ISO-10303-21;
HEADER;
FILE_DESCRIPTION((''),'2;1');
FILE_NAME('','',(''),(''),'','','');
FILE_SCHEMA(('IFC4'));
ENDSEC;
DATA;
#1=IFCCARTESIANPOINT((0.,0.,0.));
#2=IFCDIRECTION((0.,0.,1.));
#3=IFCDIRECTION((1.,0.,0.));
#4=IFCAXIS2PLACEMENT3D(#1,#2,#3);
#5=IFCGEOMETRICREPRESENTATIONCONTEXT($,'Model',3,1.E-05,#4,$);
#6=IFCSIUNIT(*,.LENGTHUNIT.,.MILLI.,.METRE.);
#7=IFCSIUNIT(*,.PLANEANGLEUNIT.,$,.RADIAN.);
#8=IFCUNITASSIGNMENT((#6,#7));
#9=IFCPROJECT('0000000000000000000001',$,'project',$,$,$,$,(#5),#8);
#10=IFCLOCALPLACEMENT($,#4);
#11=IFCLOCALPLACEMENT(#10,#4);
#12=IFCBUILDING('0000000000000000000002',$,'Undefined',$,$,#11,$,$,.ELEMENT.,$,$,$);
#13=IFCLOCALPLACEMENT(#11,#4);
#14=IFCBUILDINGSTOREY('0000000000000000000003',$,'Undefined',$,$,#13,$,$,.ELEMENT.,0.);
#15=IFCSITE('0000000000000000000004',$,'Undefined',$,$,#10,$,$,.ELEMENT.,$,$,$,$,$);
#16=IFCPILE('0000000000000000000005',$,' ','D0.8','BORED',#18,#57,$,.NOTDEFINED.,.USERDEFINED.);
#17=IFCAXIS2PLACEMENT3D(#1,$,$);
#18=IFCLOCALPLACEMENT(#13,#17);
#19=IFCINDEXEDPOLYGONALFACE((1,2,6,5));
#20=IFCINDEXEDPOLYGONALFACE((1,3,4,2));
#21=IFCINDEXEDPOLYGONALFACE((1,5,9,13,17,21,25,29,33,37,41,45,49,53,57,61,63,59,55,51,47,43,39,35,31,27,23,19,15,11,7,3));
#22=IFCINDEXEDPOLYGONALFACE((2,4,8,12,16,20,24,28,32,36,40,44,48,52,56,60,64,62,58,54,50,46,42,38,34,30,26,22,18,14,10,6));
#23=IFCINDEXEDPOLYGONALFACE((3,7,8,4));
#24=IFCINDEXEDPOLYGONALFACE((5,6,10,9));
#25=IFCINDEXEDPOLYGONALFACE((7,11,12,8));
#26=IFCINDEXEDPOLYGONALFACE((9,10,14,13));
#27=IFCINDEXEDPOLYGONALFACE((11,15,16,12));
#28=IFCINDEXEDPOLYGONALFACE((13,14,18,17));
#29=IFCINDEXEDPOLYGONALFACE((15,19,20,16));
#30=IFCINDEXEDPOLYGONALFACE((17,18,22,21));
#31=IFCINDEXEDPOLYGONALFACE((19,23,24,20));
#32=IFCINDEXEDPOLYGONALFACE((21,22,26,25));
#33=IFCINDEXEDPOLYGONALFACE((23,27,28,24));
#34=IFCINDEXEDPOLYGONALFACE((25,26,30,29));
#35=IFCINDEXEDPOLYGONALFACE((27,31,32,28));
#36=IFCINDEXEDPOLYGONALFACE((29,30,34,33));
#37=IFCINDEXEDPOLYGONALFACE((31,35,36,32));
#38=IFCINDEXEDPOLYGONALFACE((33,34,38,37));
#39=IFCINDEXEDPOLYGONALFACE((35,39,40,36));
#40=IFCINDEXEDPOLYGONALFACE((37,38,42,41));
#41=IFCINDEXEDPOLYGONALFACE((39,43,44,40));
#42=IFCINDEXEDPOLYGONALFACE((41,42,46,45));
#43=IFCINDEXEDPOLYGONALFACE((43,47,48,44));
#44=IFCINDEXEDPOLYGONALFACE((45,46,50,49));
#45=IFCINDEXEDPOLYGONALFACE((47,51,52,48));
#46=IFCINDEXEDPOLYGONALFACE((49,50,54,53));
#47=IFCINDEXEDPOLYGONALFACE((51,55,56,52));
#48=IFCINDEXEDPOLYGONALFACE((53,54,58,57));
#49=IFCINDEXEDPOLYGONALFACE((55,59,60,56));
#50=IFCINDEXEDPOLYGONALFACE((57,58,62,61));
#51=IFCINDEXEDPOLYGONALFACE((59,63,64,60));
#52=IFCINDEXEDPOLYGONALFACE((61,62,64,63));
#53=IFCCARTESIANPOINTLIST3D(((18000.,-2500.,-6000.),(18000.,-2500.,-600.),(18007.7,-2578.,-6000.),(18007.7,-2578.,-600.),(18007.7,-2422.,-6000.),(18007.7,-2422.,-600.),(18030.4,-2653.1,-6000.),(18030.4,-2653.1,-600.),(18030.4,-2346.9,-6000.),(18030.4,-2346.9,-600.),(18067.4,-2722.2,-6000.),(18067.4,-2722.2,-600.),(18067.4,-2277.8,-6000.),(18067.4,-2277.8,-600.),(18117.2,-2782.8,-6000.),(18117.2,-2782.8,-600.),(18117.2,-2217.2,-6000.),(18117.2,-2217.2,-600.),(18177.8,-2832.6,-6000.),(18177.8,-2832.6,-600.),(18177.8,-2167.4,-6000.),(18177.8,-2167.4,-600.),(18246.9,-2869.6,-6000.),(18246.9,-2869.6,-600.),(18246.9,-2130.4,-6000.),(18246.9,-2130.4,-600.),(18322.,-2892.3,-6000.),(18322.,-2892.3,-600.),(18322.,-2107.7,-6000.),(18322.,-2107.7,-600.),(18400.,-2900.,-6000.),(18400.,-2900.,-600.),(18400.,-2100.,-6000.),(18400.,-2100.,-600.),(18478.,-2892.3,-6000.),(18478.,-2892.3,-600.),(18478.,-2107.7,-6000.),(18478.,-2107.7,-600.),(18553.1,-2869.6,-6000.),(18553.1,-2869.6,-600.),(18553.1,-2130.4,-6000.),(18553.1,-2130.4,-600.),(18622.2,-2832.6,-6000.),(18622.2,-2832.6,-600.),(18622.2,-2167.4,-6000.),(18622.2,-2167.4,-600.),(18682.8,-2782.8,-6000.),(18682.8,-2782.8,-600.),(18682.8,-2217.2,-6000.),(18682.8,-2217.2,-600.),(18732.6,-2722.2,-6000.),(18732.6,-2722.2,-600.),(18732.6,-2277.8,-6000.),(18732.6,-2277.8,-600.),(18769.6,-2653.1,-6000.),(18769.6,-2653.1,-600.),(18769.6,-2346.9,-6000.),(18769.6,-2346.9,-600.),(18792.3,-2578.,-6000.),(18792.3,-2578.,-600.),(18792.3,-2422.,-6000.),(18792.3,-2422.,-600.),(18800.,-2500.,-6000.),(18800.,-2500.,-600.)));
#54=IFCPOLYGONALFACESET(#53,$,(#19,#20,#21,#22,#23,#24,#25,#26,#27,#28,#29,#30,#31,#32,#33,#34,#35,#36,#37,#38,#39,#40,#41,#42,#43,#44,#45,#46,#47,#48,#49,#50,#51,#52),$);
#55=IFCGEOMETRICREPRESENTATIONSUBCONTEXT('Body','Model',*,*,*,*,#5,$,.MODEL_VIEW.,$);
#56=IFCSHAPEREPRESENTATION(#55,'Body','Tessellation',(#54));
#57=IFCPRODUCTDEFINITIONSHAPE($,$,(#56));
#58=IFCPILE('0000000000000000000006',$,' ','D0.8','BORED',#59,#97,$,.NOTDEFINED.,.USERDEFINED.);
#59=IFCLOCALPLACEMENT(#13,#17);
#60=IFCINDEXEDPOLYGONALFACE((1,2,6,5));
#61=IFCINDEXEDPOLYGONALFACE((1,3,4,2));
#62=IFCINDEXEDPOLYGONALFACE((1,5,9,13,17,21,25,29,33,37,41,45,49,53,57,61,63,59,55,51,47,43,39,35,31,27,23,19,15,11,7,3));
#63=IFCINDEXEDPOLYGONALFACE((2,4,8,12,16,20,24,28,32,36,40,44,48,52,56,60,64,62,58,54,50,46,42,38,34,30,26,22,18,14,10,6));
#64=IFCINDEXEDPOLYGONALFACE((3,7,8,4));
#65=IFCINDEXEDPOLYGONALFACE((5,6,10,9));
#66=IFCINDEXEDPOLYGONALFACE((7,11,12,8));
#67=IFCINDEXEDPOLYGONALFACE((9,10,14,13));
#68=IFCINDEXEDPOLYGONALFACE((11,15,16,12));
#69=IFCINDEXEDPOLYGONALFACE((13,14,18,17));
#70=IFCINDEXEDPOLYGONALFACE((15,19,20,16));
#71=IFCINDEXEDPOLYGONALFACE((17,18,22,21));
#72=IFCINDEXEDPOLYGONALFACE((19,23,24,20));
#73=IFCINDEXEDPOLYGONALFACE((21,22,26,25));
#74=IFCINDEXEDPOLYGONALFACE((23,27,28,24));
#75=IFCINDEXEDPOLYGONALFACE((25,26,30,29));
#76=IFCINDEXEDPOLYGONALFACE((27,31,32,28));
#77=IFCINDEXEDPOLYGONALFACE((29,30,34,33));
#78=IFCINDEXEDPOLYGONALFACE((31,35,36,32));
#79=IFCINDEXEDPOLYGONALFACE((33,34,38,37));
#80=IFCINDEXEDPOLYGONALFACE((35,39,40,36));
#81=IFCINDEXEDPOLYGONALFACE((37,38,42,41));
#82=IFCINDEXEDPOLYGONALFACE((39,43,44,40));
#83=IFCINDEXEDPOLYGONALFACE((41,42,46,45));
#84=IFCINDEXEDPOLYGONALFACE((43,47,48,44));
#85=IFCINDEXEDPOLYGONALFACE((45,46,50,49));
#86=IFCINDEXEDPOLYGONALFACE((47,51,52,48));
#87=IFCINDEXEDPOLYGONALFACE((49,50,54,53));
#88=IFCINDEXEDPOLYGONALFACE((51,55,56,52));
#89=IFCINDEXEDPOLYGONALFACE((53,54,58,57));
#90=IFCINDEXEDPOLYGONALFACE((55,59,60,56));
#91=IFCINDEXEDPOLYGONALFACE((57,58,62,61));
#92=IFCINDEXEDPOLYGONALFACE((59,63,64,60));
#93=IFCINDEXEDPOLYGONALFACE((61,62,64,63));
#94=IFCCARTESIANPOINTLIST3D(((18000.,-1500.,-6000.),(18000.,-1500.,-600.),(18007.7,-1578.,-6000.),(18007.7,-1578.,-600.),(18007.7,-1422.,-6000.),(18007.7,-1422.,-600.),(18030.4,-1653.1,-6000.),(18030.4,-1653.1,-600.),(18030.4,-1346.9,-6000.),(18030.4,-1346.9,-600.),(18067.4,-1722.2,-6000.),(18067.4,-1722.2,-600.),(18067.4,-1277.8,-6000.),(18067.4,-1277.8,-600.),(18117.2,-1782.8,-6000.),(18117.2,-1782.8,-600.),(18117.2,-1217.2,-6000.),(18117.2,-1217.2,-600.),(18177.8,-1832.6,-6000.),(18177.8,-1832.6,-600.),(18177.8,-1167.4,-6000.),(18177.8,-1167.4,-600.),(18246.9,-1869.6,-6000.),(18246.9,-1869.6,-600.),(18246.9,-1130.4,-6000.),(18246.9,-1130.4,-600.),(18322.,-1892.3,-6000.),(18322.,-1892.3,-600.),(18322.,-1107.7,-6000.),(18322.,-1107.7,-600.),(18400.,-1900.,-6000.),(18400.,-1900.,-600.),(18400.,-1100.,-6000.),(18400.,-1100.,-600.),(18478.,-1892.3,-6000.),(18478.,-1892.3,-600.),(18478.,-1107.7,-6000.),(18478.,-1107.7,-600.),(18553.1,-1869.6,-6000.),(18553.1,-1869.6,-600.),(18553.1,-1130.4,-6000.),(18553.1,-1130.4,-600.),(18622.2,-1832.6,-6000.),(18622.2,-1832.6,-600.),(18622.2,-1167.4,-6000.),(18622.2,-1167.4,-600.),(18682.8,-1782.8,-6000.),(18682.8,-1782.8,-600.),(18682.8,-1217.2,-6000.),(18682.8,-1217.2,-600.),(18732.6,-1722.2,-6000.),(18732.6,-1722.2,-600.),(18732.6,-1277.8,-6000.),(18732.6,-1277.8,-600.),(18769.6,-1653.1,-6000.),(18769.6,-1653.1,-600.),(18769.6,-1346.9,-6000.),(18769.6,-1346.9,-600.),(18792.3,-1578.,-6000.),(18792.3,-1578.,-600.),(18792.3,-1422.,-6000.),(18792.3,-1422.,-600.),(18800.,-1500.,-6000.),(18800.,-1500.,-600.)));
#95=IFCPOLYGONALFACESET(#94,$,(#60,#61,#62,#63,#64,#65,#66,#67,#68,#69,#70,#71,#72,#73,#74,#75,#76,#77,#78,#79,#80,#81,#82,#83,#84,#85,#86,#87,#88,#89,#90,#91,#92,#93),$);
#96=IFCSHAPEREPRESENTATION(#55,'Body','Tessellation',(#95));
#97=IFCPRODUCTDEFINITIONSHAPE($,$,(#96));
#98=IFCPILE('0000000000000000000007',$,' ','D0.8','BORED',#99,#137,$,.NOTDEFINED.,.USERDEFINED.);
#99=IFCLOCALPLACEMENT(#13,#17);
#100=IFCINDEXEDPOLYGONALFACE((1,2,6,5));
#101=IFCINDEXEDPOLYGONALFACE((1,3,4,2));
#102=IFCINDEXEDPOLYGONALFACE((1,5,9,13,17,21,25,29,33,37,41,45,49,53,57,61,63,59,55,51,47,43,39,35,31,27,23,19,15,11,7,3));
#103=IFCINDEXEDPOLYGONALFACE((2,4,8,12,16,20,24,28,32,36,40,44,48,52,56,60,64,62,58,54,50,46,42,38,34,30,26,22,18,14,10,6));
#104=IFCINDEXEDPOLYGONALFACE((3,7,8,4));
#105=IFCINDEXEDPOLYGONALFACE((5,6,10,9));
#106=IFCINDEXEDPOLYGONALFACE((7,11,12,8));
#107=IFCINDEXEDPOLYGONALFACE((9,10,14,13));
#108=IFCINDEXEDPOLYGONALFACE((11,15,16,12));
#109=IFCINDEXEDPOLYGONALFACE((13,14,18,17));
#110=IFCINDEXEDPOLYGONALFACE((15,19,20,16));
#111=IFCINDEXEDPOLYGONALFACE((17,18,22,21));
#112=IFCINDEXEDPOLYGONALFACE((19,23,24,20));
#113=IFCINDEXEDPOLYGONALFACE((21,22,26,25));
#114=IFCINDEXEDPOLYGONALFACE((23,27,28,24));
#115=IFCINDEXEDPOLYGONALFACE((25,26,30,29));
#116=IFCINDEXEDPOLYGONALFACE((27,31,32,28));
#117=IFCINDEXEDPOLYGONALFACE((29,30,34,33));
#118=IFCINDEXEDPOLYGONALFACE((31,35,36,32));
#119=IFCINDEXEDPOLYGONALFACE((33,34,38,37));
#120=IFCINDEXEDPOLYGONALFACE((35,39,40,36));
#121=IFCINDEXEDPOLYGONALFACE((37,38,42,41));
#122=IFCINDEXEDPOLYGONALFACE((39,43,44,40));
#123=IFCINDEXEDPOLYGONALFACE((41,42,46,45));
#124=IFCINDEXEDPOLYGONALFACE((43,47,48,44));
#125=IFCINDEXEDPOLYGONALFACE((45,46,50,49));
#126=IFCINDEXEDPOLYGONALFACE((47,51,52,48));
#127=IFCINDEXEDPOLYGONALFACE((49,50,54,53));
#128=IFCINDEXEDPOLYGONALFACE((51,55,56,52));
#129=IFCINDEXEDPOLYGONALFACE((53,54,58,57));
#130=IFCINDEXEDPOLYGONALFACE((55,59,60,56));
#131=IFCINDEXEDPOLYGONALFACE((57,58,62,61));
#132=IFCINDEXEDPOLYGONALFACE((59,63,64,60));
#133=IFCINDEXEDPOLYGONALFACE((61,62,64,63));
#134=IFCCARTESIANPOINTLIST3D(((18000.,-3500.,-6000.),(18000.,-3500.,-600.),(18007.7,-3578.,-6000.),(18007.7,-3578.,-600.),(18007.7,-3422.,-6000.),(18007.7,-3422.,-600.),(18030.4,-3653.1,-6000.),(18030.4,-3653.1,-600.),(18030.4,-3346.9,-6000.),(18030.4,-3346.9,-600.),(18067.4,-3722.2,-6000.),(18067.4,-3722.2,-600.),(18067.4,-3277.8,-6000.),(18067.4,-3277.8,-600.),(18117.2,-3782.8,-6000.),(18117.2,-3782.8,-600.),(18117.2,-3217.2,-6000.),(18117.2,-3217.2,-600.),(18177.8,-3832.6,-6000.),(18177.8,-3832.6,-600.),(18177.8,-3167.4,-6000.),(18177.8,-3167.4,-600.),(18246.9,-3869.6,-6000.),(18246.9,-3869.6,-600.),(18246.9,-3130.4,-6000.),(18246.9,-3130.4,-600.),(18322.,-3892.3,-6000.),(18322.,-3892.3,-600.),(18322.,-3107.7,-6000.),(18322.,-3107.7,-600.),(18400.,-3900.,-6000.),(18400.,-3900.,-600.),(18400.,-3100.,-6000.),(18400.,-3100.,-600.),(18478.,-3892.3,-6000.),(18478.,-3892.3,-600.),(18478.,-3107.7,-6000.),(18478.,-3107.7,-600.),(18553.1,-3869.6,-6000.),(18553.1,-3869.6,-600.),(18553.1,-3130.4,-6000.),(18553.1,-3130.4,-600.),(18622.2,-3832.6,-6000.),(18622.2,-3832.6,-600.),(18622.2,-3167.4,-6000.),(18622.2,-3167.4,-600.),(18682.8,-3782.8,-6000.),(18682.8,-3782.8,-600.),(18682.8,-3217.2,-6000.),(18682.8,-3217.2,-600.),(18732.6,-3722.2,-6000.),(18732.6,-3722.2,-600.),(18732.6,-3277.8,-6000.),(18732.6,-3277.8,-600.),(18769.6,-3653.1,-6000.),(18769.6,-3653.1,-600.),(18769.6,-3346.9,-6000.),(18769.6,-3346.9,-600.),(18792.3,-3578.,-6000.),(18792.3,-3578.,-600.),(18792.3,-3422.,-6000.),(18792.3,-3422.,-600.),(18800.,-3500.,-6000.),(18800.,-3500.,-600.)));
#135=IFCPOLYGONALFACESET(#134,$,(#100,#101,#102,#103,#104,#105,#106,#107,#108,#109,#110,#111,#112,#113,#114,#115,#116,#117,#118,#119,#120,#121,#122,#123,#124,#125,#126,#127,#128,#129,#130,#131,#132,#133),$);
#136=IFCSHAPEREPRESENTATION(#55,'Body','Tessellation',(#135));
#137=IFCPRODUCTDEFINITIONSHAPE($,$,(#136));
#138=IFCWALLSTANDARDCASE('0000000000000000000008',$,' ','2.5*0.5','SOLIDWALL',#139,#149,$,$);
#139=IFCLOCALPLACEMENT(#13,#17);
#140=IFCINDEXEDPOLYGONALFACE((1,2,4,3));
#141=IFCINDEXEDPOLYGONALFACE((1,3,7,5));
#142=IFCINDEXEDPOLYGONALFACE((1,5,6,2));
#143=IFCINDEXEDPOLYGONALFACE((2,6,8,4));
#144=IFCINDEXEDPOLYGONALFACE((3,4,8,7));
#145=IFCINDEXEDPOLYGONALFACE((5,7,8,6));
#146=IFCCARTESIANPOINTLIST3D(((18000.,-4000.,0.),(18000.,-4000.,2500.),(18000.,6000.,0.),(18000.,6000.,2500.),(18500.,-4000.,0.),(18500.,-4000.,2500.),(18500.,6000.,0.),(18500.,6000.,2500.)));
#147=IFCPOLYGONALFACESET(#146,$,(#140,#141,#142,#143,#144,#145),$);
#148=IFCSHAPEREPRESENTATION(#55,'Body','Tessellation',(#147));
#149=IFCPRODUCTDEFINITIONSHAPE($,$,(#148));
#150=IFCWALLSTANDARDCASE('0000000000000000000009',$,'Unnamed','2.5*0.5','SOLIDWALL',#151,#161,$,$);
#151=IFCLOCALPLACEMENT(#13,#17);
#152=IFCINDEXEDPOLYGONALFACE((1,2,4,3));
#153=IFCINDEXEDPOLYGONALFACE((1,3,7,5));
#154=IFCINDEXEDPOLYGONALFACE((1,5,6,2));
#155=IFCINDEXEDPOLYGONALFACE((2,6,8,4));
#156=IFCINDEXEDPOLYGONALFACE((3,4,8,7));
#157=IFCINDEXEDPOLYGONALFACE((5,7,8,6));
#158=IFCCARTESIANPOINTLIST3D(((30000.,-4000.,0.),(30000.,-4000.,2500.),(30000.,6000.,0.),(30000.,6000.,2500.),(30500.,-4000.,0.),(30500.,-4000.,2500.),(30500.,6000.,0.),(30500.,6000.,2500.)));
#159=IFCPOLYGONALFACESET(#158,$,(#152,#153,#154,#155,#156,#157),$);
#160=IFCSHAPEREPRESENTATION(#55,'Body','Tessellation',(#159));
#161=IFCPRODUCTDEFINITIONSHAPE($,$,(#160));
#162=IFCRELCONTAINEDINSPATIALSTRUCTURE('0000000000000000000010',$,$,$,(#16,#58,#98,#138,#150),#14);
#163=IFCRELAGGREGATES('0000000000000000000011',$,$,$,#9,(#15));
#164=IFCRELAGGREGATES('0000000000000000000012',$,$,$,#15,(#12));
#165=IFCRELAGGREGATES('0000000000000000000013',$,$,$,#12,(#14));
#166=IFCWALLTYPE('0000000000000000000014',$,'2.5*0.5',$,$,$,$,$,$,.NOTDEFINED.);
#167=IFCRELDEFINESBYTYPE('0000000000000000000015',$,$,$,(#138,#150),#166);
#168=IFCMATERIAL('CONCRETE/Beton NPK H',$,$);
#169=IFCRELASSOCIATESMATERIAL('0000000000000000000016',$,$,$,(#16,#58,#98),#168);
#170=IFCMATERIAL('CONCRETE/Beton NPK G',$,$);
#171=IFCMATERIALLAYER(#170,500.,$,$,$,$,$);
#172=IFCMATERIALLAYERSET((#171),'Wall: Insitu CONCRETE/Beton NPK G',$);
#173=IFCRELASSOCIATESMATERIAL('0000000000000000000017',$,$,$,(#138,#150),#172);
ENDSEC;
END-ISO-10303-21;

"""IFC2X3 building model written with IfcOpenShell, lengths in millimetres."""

from ifc_helpers import new_model, si_unit, frame, frame_2d, origin_with_axes, origin_2d_with_axis, place, context, subcontext, project, spatial, rectangle, circle, extrude, material, layer, layer_set, layer_usage, type_object, element, save


model = new_model("IFC2X3")

# Units and contexts
model_context = context("Model", 3, precision=1e-05, world=origin_with_axes())
body_context = subcontext(model_context, "Body", "Model", "MODEL_VIEW")
ifc_project = project(units=[si_unit("LENGTHUNIT", "METRE", prefix="MILLI"), si_unit("PLANEANGLEUNIT", "RADIAN")], contexts=[model_context])

# Site, building, storey
site_placement = place(None, origin_with_axes())
site = spatial("IfcSite", under=ifc_project, at=site_placement, Name="Undefined", CompositionType="ELEMENT")
building_placement = place(site_placement, origin_with_axes())
building = spatial("IfcBuilding", under=site, at=building_placement, Name="Undefined", CompositionType="ELEMENT")
storey_placement = place(building_placement, origin_with_axes())
storey = spatial("IfcBuildingStorey", under=building, at=storey_placement, Name="Undefined", CompositionType="ELEMENT", Elevation=0.0)

# Piles
ifc_material_1 = material(Name="CONCRETE/Beton NPK H")
for number, where, z_axis, x_axis, name in (
    (1, (18400.0, -2500.0, -6000.0), (0.0, 1.0, 0.0), (0.0, 0.0, 1.0), " "),
    (2, (18400.0, -1500.0, -6000.0), (0.0, 1.0, 0.0), (0.0, 0.0, 1.0), " "),
    (3, (18400.0, -3500.0, -6000.0), (0.0, 1.0, 0.0), (0.0, 0.0, 1.0), " "),
):
    element("IfcPile", number, at=place(storey_placement, frame(where, z_axis=z_axis, x_axis=x_axis)), inside=storey, material=ifc_material_1, Name=name, Description="D0.8", ObjectType="BORED", ConstructionType="USERDEFINED", PredefinedType="NOTDEFINED", context=body_context, shape_type="SweptSolid", body=[
        extrude(circle(Radius=400.0, at=origin_2d_with_axis()), frame((5400.0, 0.0, 0.0), z_axis=(-1.0, 0.0, 0.0), x_axis=(0.0, -1.0, 0.0)), (0.0, 0.0, 1.0), 5400.0),
    ])

# Walls
ifc_material_2 = material(Name="CONCRETE/Beton NPK G")
ifc_layer = layer(ifc_material_2, 500.0)
ifc_layer_set = layer_set([ifc_layer], Name="Wall: Insitu CONCRETE/Beton NPK G")
ifc_layer_usage_1 = layer_usage(ifc_layer_set, "AXIS2", "POSITIVE", -250.0)
wall_type = type_object("IfcWallType", Name="2.5*0.5", PredefinedType="NOTDEFINED")
wall_1_placement = place(storey_placement, frame((18250.0, -4000.0, 0.0), z_axis=(0.0, 0.0, 1.0), x_axis=(0.0, 1.0, 0.0)))
element("IfcWallStandardCase", 4, at=wall_1_placement, inside=storey, type_object=wall_type, material=ifc_layer_usage_1, Name=" ", Description="2.5*0.5", ObjectType="SOLIDWALL", context=body_context, shape_type="SweptSolid", body=[
    extrude(rectangle(XDim=10000.0, YDim=500.0, at=frame_2d((0.0, 5000.0), x_axis=(0.0, -1.0))), frame((0.0, 0.0, 0.0), z_axis=(0.0, 0.0, 1.0), x_axis=(0.0, -1.0, 0.0)), (0.0, 0.0, 1.0), 2500.0),
])
ifc_layer_usage_2 = layer_usage(ifc_layer_set, "AXIS2", "POSITIVE", -250.0)
wall_2_placement = place(storey_placement, frame((30250.0, -4000.0, 0.0), z_axis=(0.0, 0.0, 1.0), x_axis=(0.0, 1.0, 0.0)))
element("IfcWallStandardCase", 5, at=wall_2_placement, inside=storey, type_object=wall_type, material=ifc_layer_usage_2, Name="Unnamed", Description="2.5*0.5", ObjectType="SOLIDWALL", context=body_context, shape_type="SweptSolid", body=[
    extrude(rectangle(XDim=10000.0, YDim=500.0, at=frame_2d((0.0, 5000.0), x_axis=(0.0, -1.0))), frame((0.0, 0.0, 0.0), z_axis=(0.0, 0.0, 1.0), x_axis=(0.0, -1.0, 0.0)), (0.0, 0.0, 1.0), 2500.0),
])

save(model, "model.ifc")
